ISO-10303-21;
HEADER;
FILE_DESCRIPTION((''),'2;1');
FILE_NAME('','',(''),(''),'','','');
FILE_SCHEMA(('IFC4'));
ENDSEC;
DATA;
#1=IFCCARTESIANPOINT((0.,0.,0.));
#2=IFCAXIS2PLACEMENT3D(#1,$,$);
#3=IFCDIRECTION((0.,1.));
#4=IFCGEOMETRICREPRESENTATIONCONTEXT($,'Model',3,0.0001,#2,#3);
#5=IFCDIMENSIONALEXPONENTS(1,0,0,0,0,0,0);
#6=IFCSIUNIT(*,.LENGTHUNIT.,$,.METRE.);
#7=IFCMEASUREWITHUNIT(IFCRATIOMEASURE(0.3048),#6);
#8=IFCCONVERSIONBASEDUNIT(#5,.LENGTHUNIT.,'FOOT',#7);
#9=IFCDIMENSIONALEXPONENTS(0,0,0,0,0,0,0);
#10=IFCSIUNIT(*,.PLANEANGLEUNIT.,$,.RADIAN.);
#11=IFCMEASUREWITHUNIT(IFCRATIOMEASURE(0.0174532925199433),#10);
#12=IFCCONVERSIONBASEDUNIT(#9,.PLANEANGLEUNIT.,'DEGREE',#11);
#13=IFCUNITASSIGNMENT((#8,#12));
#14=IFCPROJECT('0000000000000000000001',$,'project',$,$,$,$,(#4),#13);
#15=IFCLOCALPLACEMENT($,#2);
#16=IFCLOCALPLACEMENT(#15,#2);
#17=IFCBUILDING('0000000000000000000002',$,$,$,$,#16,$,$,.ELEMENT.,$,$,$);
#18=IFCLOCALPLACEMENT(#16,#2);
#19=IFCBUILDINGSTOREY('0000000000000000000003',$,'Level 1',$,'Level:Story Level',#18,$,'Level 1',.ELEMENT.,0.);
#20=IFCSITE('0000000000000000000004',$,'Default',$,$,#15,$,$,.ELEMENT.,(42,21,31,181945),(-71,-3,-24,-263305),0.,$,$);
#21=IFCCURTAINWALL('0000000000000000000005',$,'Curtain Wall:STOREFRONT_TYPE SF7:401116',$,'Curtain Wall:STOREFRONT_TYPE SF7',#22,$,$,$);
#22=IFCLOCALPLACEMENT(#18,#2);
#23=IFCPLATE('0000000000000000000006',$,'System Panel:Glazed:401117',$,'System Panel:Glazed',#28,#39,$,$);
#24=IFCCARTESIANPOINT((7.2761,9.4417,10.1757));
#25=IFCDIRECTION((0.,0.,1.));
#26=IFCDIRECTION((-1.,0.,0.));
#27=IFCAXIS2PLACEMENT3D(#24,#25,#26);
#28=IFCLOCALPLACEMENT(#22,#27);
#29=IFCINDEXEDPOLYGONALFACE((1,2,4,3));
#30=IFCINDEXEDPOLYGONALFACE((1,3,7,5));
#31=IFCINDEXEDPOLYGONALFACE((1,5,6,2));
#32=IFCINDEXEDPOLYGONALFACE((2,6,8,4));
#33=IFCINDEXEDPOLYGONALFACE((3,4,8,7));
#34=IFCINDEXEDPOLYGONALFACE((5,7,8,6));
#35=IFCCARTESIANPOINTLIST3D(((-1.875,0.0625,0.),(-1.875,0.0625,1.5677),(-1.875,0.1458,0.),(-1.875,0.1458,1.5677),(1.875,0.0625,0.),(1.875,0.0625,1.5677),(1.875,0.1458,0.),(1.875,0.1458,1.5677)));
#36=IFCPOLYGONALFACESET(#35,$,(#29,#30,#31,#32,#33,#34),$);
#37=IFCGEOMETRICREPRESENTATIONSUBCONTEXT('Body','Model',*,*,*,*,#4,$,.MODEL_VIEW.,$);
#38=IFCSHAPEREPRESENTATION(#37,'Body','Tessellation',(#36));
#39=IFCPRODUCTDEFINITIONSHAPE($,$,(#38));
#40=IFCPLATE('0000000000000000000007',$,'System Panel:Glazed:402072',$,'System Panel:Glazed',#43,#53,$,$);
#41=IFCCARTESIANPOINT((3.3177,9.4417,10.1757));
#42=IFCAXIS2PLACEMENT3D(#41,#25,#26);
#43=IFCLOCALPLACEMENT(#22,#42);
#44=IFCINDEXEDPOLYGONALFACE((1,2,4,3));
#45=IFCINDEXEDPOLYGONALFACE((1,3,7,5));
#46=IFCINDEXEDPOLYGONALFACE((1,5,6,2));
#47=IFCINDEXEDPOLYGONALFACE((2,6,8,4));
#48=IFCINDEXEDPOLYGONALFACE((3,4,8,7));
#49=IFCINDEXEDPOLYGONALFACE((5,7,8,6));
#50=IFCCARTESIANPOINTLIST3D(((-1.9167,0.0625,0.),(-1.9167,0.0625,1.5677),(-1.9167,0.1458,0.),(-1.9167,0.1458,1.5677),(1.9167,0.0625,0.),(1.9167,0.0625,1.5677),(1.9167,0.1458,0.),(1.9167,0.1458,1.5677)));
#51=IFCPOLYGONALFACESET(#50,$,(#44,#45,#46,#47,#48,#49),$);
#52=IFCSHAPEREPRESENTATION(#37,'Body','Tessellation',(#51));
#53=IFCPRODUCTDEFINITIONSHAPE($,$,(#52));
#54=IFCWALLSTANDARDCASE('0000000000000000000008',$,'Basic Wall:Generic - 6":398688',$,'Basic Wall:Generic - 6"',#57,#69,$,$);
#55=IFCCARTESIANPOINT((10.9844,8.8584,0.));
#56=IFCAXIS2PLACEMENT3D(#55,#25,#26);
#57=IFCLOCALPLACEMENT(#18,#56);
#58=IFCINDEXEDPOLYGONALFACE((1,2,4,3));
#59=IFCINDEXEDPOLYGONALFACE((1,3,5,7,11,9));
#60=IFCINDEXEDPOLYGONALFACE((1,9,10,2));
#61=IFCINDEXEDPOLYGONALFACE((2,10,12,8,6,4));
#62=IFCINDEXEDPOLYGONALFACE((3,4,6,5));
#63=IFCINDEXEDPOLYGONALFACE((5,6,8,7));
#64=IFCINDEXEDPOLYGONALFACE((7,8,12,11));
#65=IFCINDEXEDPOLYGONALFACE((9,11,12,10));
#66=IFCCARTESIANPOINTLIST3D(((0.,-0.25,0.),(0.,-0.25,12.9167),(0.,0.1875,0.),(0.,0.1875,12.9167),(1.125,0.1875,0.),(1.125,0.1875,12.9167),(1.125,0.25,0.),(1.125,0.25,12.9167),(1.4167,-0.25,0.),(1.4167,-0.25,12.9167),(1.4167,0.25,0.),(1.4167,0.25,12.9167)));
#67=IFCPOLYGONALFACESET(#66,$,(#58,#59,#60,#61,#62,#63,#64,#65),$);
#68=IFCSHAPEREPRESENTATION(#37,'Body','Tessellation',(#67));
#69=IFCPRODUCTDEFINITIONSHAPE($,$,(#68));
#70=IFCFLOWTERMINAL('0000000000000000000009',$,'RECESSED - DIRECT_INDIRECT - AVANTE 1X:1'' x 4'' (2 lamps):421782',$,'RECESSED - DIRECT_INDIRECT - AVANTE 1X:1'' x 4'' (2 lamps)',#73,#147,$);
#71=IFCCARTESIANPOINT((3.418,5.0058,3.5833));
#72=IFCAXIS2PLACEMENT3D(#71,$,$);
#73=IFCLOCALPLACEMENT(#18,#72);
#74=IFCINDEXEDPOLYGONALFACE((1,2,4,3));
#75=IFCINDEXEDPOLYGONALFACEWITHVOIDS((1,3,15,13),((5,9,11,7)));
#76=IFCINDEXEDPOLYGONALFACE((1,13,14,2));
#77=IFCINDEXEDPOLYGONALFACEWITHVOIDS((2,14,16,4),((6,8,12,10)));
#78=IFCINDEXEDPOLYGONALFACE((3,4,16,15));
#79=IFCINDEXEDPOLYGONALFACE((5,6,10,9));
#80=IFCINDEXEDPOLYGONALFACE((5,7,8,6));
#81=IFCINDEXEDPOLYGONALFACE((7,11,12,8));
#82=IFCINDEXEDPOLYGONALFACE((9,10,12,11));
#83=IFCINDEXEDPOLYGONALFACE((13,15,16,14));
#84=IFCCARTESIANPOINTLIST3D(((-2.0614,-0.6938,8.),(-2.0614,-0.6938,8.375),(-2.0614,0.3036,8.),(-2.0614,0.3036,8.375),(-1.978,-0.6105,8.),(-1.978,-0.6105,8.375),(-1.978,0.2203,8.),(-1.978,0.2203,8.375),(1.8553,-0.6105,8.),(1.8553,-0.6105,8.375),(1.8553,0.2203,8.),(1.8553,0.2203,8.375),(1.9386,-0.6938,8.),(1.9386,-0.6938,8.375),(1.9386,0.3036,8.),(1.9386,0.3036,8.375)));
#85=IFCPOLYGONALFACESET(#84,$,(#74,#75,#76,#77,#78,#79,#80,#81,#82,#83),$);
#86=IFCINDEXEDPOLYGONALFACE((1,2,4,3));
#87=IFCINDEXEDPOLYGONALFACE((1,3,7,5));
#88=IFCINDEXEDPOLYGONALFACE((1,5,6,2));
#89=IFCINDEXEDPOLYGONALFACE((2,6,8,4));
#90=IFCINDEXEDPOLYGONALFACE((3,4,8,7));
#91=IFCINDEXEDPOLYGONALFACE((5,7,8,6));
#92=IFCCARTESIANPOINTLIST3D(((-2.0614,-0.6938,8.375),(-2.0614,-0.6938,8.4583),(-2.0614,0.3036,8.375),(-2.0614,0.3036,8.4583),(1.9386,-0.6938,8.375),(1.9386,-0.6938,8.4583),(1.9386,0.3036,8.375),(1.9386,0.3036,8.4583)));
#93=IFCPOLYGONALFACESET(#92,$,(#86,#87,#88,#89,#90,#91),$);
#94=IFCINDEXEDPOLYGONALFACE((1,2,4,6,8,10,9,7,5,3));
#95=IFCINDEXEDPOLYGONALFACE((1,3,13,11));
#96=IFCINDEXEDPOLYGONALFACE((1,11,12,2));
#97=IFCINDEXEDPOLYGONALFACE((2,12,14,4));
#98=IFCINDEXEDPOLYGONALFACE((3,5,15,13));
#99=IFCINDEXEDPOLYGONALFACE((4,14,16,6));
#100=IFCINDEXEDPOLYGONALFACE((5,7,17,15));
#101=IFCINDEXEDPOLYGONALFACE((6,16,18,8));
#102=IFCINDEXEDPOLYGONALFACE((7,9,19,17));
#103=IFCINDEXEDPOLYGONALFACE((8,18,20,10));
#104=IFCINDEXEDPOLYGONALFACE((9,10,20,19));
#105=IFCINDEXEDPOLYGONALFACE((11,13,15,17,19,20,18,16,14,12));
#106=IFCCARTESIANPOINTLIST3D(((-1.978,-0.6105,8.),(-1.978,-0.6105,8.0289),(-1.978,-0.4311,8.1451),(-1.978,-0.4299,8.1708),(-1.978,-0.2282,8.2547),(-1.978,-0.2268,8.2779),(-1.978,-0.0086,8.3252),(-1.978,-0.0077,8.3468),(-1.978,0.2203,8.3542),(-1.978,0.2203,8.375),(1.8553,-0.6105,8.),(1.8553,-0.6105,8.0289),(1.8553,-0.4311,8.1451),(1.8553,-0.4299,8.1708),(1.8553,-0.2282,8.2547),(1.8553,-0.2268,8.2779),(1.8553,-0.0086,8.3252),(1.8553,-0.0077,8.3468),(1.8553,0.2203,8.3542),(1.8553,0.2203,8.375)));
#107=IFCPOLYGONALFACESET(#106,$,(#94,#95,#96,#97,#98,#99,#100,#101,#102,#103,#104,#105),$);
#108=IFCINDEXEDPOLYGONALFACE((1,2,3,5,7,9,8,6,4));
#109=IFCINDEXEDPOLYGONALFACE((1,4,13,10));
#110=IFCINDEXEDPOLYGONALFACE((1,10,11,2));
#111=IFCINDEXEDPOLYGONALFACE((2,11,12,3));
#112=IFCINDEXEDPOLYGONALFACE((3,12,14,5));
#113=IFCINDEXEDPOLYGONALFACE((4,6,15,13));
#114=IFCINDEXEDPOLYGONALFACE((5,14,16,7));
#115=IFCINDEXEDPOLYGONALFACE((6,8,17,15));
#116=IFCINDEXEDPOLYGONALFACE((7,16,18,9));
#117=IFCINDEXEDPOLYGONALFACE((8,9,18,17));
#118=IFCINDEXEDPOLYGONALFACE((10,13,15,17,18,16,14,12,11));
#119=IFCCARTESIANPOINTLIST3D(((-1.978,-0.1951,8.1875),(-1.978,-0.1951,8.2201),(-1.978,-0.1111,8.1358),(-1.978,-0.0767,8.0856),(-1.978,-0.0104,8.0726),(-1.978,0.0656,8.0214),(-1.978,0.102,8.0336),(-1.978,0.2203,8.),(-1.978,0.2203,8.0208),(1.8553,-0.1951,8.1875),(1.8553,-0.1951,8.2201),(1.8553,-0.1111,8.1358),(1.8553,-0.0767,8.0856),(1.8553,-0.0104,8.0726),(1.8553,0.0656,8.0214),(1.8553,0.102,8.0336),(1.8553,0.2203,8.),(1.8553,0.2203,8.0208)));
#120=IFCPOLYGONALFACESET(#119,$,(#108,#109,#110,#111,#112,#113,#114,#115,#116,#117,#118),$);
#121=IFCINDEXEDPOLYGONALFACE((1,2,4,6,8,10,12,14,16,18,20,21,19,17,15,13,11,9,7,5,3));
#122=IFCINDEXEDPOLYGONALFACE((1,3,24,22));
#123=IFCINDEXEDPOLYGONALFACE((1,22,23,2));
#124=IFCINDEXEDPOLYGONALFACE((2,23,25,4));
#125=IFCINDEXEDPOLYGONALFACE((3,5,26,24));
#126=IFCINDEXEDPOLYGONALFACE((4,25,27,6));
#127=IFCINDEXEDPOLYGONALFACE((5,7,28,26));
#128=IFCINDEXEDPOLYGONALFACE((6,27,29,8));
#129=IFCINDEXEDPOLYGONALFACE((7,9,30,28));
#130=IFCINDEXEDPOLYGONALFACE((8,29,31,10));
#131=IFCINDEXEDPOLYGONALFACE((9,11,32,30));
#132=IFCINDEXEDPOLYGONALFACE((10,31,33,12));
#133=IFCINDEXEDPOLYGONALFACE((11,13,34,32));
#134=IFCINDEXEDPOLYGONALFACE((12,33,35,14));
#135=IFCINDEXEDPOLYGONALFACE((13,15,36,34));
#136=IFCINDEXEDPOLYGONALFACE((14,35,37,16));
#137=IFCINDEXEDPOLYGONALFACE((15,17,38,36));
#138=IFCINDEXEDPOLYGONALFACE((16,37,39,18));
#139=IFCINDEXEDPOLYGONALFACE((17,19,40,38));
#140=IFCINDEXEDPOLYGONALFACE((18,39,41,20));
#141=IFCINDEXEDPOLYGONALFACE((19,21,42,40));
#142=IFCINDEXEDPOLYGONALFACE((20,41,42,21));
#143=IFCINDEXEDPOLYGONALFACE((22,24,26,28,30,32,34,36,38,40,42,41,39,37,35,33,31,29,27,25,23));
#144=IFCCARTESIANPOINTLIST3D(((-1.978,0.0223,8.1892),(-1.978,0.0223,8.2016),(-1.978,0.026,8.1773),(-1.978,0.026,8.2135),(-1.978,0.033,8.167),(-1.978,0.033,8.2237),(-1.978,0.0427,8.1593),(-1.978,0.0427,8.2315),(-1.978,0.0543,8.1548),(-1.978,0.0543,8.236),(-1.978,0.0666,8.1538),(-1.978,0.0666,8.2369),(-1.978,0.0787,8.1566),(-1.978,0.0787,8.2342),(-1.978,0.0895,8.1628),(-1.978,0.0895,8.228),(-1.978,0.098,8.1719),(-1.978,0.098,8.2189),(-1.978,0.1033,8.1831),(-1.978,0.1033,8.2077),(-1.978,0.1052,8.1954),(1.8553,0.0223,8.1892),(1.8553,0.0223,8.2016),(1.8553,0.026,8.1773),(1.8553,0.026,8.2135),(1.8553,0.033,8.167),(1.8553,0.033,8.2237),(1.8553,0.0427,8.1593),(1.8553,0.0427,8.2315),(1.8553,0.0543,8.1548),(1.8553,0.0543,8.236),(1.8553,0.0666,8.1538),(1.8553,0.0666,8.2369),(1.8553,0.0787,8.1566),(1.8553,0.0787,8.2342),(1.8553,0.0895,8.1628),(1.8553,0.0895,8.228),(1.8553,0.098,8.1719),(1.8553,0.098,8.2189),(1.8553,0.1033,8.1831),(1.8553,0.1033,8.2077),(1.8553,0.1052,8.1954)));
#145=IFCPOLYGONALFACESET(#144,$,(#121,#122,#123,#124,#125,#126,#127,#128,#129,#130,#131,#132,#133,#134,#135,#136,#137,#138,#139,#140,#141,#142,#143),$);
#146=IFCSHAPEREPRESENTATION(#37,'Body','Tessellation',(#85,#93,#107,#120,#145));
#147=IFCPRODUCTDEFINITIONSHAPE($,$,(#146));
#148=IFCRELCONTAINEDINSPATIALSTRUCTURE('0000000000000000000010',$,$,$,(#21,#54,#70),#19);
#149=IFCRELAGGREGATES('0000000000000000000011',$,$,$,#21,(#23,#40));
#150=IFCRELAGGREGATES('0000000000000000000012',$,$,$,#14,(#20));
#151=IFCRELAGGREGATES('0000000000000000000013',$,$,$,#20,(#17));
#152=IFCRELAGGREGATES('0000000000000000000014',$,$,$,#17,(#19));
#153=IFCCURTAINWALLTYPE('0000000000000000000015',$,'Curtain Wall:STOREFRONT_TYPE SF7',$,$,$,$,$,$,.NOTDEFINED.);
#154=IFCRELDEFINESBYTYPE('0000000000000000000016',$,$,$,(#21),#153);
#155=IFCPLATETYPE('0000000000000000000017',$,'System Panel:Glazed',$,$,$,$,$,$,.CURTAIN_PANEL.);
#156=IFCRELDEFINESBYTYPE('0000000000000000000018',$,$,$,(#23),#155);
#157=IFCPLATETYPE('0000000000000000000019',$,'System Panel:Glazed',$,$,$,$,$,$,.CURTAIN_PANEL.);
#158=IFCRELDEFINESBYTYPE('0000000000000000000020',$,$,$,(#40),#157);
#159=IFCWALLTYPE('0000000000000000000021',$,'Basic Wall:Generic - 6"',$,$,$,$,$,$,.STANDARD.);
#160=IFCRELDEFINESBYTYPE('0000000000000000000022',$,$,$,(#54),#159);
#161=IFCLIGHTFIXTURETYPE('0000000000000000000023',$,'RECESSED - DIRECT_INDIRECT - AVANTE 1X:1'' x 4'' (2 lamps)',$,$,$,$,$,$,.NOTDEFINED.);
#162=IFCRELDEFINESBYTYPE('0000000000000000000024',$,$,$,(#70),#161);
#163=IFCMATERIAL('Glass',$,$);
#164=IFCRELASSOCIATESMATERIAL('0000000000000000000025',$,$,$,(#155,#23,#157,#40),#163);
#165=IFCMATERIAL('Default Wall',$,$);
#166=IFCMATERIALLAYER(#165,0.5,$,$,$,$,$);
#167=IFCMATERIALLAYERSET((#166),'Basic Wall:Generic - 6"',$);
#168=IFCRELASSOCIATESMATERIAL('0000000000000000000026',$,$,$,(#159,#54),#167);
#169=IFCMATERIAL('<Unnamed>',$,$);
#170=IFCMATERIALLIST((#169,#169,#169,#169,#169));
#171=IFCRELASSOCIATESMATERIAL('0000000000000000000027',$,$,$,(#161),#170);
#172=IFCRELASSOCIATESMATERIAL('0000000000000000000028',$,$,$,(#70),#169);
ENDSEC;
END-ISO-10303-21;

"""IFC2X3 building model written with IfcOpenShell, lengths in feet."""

from ifc_helpers import new_model, entity, si_unit, converted_unit, direction, frame, frame_2d, origin, origin_2d_with_axis, place, context, subcontext, project, spatial, polyline, circle_curve, parameter, trimmed, segment, composite_curve, rectangle, circle, outline, extrude, clip, bounded_halfspace, source, transform, mapped, material, material_list, layer, layer_set, layer_usage, type_object, type_shapes, element, aggregate, save


model = new_model("IFC2X3")

# Units and contexts
model_context = context("Model", 3, precision=0.0001, world=origin(), true_north=direction((0.0, 1.0)))
body_context = subcontext(model_context, "Body", "Model", "MODEL_VIEW")
ifc_project = project(units=[converted_unit("LENGTHUNIT", "FOOT", entity("IfcRatioMeasure", 0.3048), si_unit("LENGTHUNIT", "METRE"), dimensions=[1, 0, 0, 0, 0, 0, 0]), converted_unit("PLANEANGLEUNIT", "DEGREE", entity("IfcRatioMeasure", 0.0174532925199433), si_unit("PLANEANGLEUNIT", "RADIAN"), dimensions=[0, 0, 0, 0, 0, 0, 0])], contexts=[model_context])

# Site, building, storey
site_placement = place(None, origin())
site = spatial("IfcSite", under=ifc_project, at=site_placement, Name="Default", CompositionType="ELEMENT", RefLatitude=(42, 21, 31, 181945), RefLongitude=(-71, -3, -24, -263305), RefElevation=0.0)
building_placement = place(site_placement, origin())
building = spatial("IfcBuilding", under=site, at=building_placement, CompositionType="ELEMENT")
storey_placement = place(building_placement, origin())
storey = spatial("IfcBuildingStorey", under=building, at=storey_placement, Name="Level 1", ObjectType="Level:Story Level", LongName="Level 1", CompositionType="ELEMENT", Elevation=0.0)

# Curtain wall, plates
curtain_wall_type = type_object("IfcCurtainWallType", Name="Curtain Wall:STOREFRONT_TYPE SF7", PredefinedType="NOTDEFINED")
curtain_wall_placement = place(storey_placement, origin())
curtain_wall = element("IfcCurtainWall", 1, at=curtain_wall_placement, inside=storey, type_object=curtain_wall_type, Name="Curtain Wall:STOREFRONT_TYPE SF7:401116", ObjectType="Curtain Wall:STOREFRONT_TYPE SF7")
ifc_material_1 = material(Name="Glass")
plate_type_1 = type_object("IfcPlateType", Name="System Panel:Glazed", PredefinedType="CURTAIN_PANEL", material=ifc_material_1)
shared_shape_1 = source(origin(), body_context, "Body", "SweptSolid", [
    extrude(rectangle(XDim=0.0833, YDim=3.75, at=frame_2d((0.0, 0.0), x_axis=(1.0, 0.0))), frame((0.0, 0.1042, 0.0), z_axis=(0.0, 0.0, 1.0), x_axis=(0.0, 1.0, 0.0)), (0.0, 0.0, 1.0), 1.5677),
])
type_shapes(plate_type_1, [shared_shape_1])
plate_1_placement = place(curtain_wall_placement, frame((7.2761, 9.4417, 10.1757), z_axis=(0.0, 0.0, 1.0), x_axis=(-1.0, 0.0, 0.0)))
plate_1 = element("IfcPlate", 2, at=plate_1_placement, type_object=plate_type_1, material=ifc_material_1, Name="System Panel:Glazed:401117", ObjectType="System Panel:Glazed", context=body_context, shape_type="MappedRepresentation", body=[
    mapped(shared_shape_1, transform((0.0, 0.0, 0.0), scale=1.0)),
])
plate_type_2 = type_object("IfcPlateType", Name="System Panel:Glazed", PredefinedType="CURTAIN_PANEL", material=ifc_material_1)
shared_shape_2 = source(origin(), body_context, "Body", "SweptSolid", [
    extrude(rectangle(XDim=0.0833, YDim=3.8333, at=frame_2d((0.0, 0.0), x_axis=(1.0, 0.0))), frame((0.0, 0.1042, 0.0), z_axis=(0.0, 0.0, 1.0), x_axis=(0.0, 1.0, 0.0)), (0.0, 0.0, 1.0), 1.5677),
])
type_shapes(plate_type_2, [shared_shape_2])
plate_2_placement = place(curtain_wall_placement, frame((3.3177, 9.4417, 10.1757), z_axis=(0.0, 0.0, 1.0), x_axis=(-1.0, 0.0, 0.0)))
plate_2 = element("IfcPlate", 3, at=plate_2_placement, type_object=plate_type_2, material=ifc_material_1, Name="System Panel:Glazed:402072", ObjectType="System Panel:Glazed", context=body_context, shape_type="MappedRepresentation", body=[
    mapped(shared_shape_2, transform((0.0, 0.0, 0.0), scale=1.0)),
])
aggregate(curtain_wall, [plate_1, plate_2])

# Shared definitions
ifc_material_2 = material(Name="Default Wall")

# Wall, opening
ifc_layer_1 = layer(ifc_material_2, 0.5)
ifc_layer_set_1 = layer_set([ifc_layer_1], Name="Basic Wall:Generic - 6\"")
ifc_layer_usage_1 = layer_usage(ifc_layer_set_1, "AXIS2", "NEGATIVE", 0.25)
wall_type_1 = type_object("IfcWallType", Name="Basic Wall:Generic - 6\"", PredefinedType="STANDARD", material=ifc_layer_set_1)
wall_1_placement = place(storey_placement, frame((10.9844, 8.8584, 0.0), z_axis=(0.0, 0.0, 1.0), x_axis=(-1.0, 0.0, 0.0)))
wall_1 = element("IfcWallStandardCase", 4, at=wall_1_placement, inside=storey, type_object=wall_type_1, material=ifc_layer_usage_1, Name="Basic Wall:Generic - 6\":398688", ObjectType="Basic Wall:Generic - 6\"", context=body_context, shape_type="Clipping", body=[
    clip(clip(extrude(rectangle(XDim=1.4167, YDim=0.5, at=frame_2d((0.7083, 0.0), x_axis=(-1.0, 0.0))), origin(), (0.0, 0.0, 1.0), 12.9167), bounded_halfspace(frame((1.125, 0.1875, 12.9167), z_axis=(0.0, -1.0, 0.0), x_axis=(1.0, 0.0, 0.0)), True, frame((1.125, 0.1875, 12.9167), z_axis=(0.0, -1.0, 0.0), x_axis=(1.0, 0.0, 0.0)), polyline([(0.0, 0.0), (-1.125, 0.0), (-1.125, -12.9167), (0.0, -12.9167), (0.0, 0.0)]))), bounded_halfspace(frame((1.125, 0.1875, 0.0), z_axis=(1.0, 0.0, 0.0), x_axis=(0.0, 1.0, 0.0)), True, frame((1.125, 0.1875, 0.0), z_axis=(1.0, 0.0, 0.0), x_axis=(0.0, 1.0, 0.0)), polyline([(0.0, 0.0), (0.0625, 0.0), (0.0625, 12.9167), (0.0, 12.9167), (0.0, 0.0)]))),
])
opening_1_placement = place(wall_1_placement, origin())
element("IfcOpeningElement", 5, at=opening_1_placement, cuts=wall_1, ObjectType="Opening", context=body_context, shape_type="SweptSolid", body=[
    extrude(rectangle(XDim=1.901, YDim=20.0, at=origin_2d_with_axis()), frame((11.6667, -0.75, 10.9595), z_axis=(0.0, 1.0, 0.0), x_axis=(0.0, 0.0, 1.0)), (0.0, 0.0, 1.0), 1.5),
])

# Flow terminal
ifc_material_3 = material(Name="<Unnamed>")
ifc_material_list = material_list([ifc_material_3, ifc_material_3, ifc_material_3, ifc_material_3, ifc_material_3])
light_fixture_type = type_object("IfcLightFixtureType", Name="RECESSED - DIRECT_INDIRECT - AVANTE 1X:1' x 4' (2 lamps)", PredefinedType="NOTDEFINED", material=ifc_material_list)
shared_shape_3 = source(origin(), body_context, "Body", "SweptSolid", [
    extrude(outline(polyline([(-2.0, -0.4987), (2.0, -0.4987), (2.0, 0.4987), (-2.0, 0.4987), (-2.0, -0.4987)]), holes=[polyline([(-1.9167, -0.4154), (-1.9167, 0.4154), (1.9167, 0.4154), (1.9167, -0.4154), (-1.9167, -0.4154)])]), frame((-0.0614, -0.1951, 8.0), z_axis=(0.0, 0.0, 1.0), x_axis=(-1.0, 0.0, 0.0)), (0.0, 0.0, 1.0), 0.375),
    extrude(rectangle(XDim=4.0, YDim=0.9974, at=origin_2d_with_axis()), frame((-0.0614, -0.1951, 8.375), z_axis=(0.0, 0.0, 1.0), x_axis=(-1.0, 0.0, 0.0)), (0.0, 0.0, 1.0), 0.0833),
    extrude(outline(composite_curve([segment(trimmed(circle_curve(frame_2d((-1.0846, 0.4571), x_axis=(-1.0, 0.0)), 1.25), [parameter(135.734122)], [parameter(178.085644)], True, "PARAMETER"), False, "CONTINUOUS"), segment(polyline([(-0.1895, -0.4154), (-0.1606, -0.4154)]), True, "CONTINUOUS"), segment(trimmed(circle_curve(frame_2d((-1.0846, 0.4571), x_axis=(-1.0, 0.0)), 1.2708), [parameter(136.642648)], [parameter(178.117038)], True, "PARAMETER"), True, "CONTINUOUS"), segment(polyline([(0.1855, 0.4154), (0.1647, 0.4154)]), True, "CONTINUOUS")], self_intersect=False)), frame((-1.978, -0.1951, 8.1895), z_axis=(-1.0, 0.0, 0.0), x_axis=(0.0, 0.0, 1.0)), (0.0, 0.0, -1.0), 3.8333),
    extrude(outline(composite_curve([segment(polyline([(0.0863, -0.2077), (0.1071, -0.2077)]), True, "CONTINUOUS"), segment(trimmed(circle_curve(frame_2d((-0.4397, -0.2045), x_axis=(1.0, 0.0)), 0.5468), [parameter(359.668292)], [parameter(48.921556)], True, "PARAMETER"), True, "CONTINUOUS"), segment(polyline([(-0.0804, 0.2077), (-0.113, 0.2077)]), True, "CONTINUOUS"), segment(trimmed(circle_curve(frame_2d((-0.4397, -0.2045), x_axis=(1.0, 0.0)), 0.526), [parameter(359.655153)], [parameter(51.59762)], True, "PARAMETER"), False, "CONTINUOUS")], self_intersect=False)), frame((-1.978, 0.0126, 8.1071), z_axis=(-1.0, 0.0, 0.0), x_axis=(0.0, 0.0, -1.0)), (0.0, 0.0, -1.0), 3.8333),
    extrude(circle(Radius=0.0417, at=origin_2d_with_axis()), frame((-1.978, 0.0635, 8.1954), z_axis=(1.0, 0.0, 0.0), x_axis=(0.0, 1.0, 0.0)), (0.0, 0.0, 1.0), 3.8333),
])
type_shapes(light_fixture_type, [shared_shape_3])
flow_terminal_placement = place(storey_placement, frame((3.418, 5.0058, 3.5833)))
element("IfcFlowTerminal", 6, at=flow_terminal_placement, inside=storey, type_object=light_fixture_type, material=ifc_material_3, Name="RECESSED - DIRECT_INDIRECT - AVANTE 1X:1' x 4' (2 lamps):421782", ObjectType="RECESSED - DIRECT_INDIRECT - AVANTE 1X:1' x 4' (2 lamps)", context=body_context, shape_type="MappedRepresentation", body=[
    mapped(shared_shape_3, transform((0.0, 0.0, 0.0), scale=1.0)),
])

save(model, "model.ifc")
